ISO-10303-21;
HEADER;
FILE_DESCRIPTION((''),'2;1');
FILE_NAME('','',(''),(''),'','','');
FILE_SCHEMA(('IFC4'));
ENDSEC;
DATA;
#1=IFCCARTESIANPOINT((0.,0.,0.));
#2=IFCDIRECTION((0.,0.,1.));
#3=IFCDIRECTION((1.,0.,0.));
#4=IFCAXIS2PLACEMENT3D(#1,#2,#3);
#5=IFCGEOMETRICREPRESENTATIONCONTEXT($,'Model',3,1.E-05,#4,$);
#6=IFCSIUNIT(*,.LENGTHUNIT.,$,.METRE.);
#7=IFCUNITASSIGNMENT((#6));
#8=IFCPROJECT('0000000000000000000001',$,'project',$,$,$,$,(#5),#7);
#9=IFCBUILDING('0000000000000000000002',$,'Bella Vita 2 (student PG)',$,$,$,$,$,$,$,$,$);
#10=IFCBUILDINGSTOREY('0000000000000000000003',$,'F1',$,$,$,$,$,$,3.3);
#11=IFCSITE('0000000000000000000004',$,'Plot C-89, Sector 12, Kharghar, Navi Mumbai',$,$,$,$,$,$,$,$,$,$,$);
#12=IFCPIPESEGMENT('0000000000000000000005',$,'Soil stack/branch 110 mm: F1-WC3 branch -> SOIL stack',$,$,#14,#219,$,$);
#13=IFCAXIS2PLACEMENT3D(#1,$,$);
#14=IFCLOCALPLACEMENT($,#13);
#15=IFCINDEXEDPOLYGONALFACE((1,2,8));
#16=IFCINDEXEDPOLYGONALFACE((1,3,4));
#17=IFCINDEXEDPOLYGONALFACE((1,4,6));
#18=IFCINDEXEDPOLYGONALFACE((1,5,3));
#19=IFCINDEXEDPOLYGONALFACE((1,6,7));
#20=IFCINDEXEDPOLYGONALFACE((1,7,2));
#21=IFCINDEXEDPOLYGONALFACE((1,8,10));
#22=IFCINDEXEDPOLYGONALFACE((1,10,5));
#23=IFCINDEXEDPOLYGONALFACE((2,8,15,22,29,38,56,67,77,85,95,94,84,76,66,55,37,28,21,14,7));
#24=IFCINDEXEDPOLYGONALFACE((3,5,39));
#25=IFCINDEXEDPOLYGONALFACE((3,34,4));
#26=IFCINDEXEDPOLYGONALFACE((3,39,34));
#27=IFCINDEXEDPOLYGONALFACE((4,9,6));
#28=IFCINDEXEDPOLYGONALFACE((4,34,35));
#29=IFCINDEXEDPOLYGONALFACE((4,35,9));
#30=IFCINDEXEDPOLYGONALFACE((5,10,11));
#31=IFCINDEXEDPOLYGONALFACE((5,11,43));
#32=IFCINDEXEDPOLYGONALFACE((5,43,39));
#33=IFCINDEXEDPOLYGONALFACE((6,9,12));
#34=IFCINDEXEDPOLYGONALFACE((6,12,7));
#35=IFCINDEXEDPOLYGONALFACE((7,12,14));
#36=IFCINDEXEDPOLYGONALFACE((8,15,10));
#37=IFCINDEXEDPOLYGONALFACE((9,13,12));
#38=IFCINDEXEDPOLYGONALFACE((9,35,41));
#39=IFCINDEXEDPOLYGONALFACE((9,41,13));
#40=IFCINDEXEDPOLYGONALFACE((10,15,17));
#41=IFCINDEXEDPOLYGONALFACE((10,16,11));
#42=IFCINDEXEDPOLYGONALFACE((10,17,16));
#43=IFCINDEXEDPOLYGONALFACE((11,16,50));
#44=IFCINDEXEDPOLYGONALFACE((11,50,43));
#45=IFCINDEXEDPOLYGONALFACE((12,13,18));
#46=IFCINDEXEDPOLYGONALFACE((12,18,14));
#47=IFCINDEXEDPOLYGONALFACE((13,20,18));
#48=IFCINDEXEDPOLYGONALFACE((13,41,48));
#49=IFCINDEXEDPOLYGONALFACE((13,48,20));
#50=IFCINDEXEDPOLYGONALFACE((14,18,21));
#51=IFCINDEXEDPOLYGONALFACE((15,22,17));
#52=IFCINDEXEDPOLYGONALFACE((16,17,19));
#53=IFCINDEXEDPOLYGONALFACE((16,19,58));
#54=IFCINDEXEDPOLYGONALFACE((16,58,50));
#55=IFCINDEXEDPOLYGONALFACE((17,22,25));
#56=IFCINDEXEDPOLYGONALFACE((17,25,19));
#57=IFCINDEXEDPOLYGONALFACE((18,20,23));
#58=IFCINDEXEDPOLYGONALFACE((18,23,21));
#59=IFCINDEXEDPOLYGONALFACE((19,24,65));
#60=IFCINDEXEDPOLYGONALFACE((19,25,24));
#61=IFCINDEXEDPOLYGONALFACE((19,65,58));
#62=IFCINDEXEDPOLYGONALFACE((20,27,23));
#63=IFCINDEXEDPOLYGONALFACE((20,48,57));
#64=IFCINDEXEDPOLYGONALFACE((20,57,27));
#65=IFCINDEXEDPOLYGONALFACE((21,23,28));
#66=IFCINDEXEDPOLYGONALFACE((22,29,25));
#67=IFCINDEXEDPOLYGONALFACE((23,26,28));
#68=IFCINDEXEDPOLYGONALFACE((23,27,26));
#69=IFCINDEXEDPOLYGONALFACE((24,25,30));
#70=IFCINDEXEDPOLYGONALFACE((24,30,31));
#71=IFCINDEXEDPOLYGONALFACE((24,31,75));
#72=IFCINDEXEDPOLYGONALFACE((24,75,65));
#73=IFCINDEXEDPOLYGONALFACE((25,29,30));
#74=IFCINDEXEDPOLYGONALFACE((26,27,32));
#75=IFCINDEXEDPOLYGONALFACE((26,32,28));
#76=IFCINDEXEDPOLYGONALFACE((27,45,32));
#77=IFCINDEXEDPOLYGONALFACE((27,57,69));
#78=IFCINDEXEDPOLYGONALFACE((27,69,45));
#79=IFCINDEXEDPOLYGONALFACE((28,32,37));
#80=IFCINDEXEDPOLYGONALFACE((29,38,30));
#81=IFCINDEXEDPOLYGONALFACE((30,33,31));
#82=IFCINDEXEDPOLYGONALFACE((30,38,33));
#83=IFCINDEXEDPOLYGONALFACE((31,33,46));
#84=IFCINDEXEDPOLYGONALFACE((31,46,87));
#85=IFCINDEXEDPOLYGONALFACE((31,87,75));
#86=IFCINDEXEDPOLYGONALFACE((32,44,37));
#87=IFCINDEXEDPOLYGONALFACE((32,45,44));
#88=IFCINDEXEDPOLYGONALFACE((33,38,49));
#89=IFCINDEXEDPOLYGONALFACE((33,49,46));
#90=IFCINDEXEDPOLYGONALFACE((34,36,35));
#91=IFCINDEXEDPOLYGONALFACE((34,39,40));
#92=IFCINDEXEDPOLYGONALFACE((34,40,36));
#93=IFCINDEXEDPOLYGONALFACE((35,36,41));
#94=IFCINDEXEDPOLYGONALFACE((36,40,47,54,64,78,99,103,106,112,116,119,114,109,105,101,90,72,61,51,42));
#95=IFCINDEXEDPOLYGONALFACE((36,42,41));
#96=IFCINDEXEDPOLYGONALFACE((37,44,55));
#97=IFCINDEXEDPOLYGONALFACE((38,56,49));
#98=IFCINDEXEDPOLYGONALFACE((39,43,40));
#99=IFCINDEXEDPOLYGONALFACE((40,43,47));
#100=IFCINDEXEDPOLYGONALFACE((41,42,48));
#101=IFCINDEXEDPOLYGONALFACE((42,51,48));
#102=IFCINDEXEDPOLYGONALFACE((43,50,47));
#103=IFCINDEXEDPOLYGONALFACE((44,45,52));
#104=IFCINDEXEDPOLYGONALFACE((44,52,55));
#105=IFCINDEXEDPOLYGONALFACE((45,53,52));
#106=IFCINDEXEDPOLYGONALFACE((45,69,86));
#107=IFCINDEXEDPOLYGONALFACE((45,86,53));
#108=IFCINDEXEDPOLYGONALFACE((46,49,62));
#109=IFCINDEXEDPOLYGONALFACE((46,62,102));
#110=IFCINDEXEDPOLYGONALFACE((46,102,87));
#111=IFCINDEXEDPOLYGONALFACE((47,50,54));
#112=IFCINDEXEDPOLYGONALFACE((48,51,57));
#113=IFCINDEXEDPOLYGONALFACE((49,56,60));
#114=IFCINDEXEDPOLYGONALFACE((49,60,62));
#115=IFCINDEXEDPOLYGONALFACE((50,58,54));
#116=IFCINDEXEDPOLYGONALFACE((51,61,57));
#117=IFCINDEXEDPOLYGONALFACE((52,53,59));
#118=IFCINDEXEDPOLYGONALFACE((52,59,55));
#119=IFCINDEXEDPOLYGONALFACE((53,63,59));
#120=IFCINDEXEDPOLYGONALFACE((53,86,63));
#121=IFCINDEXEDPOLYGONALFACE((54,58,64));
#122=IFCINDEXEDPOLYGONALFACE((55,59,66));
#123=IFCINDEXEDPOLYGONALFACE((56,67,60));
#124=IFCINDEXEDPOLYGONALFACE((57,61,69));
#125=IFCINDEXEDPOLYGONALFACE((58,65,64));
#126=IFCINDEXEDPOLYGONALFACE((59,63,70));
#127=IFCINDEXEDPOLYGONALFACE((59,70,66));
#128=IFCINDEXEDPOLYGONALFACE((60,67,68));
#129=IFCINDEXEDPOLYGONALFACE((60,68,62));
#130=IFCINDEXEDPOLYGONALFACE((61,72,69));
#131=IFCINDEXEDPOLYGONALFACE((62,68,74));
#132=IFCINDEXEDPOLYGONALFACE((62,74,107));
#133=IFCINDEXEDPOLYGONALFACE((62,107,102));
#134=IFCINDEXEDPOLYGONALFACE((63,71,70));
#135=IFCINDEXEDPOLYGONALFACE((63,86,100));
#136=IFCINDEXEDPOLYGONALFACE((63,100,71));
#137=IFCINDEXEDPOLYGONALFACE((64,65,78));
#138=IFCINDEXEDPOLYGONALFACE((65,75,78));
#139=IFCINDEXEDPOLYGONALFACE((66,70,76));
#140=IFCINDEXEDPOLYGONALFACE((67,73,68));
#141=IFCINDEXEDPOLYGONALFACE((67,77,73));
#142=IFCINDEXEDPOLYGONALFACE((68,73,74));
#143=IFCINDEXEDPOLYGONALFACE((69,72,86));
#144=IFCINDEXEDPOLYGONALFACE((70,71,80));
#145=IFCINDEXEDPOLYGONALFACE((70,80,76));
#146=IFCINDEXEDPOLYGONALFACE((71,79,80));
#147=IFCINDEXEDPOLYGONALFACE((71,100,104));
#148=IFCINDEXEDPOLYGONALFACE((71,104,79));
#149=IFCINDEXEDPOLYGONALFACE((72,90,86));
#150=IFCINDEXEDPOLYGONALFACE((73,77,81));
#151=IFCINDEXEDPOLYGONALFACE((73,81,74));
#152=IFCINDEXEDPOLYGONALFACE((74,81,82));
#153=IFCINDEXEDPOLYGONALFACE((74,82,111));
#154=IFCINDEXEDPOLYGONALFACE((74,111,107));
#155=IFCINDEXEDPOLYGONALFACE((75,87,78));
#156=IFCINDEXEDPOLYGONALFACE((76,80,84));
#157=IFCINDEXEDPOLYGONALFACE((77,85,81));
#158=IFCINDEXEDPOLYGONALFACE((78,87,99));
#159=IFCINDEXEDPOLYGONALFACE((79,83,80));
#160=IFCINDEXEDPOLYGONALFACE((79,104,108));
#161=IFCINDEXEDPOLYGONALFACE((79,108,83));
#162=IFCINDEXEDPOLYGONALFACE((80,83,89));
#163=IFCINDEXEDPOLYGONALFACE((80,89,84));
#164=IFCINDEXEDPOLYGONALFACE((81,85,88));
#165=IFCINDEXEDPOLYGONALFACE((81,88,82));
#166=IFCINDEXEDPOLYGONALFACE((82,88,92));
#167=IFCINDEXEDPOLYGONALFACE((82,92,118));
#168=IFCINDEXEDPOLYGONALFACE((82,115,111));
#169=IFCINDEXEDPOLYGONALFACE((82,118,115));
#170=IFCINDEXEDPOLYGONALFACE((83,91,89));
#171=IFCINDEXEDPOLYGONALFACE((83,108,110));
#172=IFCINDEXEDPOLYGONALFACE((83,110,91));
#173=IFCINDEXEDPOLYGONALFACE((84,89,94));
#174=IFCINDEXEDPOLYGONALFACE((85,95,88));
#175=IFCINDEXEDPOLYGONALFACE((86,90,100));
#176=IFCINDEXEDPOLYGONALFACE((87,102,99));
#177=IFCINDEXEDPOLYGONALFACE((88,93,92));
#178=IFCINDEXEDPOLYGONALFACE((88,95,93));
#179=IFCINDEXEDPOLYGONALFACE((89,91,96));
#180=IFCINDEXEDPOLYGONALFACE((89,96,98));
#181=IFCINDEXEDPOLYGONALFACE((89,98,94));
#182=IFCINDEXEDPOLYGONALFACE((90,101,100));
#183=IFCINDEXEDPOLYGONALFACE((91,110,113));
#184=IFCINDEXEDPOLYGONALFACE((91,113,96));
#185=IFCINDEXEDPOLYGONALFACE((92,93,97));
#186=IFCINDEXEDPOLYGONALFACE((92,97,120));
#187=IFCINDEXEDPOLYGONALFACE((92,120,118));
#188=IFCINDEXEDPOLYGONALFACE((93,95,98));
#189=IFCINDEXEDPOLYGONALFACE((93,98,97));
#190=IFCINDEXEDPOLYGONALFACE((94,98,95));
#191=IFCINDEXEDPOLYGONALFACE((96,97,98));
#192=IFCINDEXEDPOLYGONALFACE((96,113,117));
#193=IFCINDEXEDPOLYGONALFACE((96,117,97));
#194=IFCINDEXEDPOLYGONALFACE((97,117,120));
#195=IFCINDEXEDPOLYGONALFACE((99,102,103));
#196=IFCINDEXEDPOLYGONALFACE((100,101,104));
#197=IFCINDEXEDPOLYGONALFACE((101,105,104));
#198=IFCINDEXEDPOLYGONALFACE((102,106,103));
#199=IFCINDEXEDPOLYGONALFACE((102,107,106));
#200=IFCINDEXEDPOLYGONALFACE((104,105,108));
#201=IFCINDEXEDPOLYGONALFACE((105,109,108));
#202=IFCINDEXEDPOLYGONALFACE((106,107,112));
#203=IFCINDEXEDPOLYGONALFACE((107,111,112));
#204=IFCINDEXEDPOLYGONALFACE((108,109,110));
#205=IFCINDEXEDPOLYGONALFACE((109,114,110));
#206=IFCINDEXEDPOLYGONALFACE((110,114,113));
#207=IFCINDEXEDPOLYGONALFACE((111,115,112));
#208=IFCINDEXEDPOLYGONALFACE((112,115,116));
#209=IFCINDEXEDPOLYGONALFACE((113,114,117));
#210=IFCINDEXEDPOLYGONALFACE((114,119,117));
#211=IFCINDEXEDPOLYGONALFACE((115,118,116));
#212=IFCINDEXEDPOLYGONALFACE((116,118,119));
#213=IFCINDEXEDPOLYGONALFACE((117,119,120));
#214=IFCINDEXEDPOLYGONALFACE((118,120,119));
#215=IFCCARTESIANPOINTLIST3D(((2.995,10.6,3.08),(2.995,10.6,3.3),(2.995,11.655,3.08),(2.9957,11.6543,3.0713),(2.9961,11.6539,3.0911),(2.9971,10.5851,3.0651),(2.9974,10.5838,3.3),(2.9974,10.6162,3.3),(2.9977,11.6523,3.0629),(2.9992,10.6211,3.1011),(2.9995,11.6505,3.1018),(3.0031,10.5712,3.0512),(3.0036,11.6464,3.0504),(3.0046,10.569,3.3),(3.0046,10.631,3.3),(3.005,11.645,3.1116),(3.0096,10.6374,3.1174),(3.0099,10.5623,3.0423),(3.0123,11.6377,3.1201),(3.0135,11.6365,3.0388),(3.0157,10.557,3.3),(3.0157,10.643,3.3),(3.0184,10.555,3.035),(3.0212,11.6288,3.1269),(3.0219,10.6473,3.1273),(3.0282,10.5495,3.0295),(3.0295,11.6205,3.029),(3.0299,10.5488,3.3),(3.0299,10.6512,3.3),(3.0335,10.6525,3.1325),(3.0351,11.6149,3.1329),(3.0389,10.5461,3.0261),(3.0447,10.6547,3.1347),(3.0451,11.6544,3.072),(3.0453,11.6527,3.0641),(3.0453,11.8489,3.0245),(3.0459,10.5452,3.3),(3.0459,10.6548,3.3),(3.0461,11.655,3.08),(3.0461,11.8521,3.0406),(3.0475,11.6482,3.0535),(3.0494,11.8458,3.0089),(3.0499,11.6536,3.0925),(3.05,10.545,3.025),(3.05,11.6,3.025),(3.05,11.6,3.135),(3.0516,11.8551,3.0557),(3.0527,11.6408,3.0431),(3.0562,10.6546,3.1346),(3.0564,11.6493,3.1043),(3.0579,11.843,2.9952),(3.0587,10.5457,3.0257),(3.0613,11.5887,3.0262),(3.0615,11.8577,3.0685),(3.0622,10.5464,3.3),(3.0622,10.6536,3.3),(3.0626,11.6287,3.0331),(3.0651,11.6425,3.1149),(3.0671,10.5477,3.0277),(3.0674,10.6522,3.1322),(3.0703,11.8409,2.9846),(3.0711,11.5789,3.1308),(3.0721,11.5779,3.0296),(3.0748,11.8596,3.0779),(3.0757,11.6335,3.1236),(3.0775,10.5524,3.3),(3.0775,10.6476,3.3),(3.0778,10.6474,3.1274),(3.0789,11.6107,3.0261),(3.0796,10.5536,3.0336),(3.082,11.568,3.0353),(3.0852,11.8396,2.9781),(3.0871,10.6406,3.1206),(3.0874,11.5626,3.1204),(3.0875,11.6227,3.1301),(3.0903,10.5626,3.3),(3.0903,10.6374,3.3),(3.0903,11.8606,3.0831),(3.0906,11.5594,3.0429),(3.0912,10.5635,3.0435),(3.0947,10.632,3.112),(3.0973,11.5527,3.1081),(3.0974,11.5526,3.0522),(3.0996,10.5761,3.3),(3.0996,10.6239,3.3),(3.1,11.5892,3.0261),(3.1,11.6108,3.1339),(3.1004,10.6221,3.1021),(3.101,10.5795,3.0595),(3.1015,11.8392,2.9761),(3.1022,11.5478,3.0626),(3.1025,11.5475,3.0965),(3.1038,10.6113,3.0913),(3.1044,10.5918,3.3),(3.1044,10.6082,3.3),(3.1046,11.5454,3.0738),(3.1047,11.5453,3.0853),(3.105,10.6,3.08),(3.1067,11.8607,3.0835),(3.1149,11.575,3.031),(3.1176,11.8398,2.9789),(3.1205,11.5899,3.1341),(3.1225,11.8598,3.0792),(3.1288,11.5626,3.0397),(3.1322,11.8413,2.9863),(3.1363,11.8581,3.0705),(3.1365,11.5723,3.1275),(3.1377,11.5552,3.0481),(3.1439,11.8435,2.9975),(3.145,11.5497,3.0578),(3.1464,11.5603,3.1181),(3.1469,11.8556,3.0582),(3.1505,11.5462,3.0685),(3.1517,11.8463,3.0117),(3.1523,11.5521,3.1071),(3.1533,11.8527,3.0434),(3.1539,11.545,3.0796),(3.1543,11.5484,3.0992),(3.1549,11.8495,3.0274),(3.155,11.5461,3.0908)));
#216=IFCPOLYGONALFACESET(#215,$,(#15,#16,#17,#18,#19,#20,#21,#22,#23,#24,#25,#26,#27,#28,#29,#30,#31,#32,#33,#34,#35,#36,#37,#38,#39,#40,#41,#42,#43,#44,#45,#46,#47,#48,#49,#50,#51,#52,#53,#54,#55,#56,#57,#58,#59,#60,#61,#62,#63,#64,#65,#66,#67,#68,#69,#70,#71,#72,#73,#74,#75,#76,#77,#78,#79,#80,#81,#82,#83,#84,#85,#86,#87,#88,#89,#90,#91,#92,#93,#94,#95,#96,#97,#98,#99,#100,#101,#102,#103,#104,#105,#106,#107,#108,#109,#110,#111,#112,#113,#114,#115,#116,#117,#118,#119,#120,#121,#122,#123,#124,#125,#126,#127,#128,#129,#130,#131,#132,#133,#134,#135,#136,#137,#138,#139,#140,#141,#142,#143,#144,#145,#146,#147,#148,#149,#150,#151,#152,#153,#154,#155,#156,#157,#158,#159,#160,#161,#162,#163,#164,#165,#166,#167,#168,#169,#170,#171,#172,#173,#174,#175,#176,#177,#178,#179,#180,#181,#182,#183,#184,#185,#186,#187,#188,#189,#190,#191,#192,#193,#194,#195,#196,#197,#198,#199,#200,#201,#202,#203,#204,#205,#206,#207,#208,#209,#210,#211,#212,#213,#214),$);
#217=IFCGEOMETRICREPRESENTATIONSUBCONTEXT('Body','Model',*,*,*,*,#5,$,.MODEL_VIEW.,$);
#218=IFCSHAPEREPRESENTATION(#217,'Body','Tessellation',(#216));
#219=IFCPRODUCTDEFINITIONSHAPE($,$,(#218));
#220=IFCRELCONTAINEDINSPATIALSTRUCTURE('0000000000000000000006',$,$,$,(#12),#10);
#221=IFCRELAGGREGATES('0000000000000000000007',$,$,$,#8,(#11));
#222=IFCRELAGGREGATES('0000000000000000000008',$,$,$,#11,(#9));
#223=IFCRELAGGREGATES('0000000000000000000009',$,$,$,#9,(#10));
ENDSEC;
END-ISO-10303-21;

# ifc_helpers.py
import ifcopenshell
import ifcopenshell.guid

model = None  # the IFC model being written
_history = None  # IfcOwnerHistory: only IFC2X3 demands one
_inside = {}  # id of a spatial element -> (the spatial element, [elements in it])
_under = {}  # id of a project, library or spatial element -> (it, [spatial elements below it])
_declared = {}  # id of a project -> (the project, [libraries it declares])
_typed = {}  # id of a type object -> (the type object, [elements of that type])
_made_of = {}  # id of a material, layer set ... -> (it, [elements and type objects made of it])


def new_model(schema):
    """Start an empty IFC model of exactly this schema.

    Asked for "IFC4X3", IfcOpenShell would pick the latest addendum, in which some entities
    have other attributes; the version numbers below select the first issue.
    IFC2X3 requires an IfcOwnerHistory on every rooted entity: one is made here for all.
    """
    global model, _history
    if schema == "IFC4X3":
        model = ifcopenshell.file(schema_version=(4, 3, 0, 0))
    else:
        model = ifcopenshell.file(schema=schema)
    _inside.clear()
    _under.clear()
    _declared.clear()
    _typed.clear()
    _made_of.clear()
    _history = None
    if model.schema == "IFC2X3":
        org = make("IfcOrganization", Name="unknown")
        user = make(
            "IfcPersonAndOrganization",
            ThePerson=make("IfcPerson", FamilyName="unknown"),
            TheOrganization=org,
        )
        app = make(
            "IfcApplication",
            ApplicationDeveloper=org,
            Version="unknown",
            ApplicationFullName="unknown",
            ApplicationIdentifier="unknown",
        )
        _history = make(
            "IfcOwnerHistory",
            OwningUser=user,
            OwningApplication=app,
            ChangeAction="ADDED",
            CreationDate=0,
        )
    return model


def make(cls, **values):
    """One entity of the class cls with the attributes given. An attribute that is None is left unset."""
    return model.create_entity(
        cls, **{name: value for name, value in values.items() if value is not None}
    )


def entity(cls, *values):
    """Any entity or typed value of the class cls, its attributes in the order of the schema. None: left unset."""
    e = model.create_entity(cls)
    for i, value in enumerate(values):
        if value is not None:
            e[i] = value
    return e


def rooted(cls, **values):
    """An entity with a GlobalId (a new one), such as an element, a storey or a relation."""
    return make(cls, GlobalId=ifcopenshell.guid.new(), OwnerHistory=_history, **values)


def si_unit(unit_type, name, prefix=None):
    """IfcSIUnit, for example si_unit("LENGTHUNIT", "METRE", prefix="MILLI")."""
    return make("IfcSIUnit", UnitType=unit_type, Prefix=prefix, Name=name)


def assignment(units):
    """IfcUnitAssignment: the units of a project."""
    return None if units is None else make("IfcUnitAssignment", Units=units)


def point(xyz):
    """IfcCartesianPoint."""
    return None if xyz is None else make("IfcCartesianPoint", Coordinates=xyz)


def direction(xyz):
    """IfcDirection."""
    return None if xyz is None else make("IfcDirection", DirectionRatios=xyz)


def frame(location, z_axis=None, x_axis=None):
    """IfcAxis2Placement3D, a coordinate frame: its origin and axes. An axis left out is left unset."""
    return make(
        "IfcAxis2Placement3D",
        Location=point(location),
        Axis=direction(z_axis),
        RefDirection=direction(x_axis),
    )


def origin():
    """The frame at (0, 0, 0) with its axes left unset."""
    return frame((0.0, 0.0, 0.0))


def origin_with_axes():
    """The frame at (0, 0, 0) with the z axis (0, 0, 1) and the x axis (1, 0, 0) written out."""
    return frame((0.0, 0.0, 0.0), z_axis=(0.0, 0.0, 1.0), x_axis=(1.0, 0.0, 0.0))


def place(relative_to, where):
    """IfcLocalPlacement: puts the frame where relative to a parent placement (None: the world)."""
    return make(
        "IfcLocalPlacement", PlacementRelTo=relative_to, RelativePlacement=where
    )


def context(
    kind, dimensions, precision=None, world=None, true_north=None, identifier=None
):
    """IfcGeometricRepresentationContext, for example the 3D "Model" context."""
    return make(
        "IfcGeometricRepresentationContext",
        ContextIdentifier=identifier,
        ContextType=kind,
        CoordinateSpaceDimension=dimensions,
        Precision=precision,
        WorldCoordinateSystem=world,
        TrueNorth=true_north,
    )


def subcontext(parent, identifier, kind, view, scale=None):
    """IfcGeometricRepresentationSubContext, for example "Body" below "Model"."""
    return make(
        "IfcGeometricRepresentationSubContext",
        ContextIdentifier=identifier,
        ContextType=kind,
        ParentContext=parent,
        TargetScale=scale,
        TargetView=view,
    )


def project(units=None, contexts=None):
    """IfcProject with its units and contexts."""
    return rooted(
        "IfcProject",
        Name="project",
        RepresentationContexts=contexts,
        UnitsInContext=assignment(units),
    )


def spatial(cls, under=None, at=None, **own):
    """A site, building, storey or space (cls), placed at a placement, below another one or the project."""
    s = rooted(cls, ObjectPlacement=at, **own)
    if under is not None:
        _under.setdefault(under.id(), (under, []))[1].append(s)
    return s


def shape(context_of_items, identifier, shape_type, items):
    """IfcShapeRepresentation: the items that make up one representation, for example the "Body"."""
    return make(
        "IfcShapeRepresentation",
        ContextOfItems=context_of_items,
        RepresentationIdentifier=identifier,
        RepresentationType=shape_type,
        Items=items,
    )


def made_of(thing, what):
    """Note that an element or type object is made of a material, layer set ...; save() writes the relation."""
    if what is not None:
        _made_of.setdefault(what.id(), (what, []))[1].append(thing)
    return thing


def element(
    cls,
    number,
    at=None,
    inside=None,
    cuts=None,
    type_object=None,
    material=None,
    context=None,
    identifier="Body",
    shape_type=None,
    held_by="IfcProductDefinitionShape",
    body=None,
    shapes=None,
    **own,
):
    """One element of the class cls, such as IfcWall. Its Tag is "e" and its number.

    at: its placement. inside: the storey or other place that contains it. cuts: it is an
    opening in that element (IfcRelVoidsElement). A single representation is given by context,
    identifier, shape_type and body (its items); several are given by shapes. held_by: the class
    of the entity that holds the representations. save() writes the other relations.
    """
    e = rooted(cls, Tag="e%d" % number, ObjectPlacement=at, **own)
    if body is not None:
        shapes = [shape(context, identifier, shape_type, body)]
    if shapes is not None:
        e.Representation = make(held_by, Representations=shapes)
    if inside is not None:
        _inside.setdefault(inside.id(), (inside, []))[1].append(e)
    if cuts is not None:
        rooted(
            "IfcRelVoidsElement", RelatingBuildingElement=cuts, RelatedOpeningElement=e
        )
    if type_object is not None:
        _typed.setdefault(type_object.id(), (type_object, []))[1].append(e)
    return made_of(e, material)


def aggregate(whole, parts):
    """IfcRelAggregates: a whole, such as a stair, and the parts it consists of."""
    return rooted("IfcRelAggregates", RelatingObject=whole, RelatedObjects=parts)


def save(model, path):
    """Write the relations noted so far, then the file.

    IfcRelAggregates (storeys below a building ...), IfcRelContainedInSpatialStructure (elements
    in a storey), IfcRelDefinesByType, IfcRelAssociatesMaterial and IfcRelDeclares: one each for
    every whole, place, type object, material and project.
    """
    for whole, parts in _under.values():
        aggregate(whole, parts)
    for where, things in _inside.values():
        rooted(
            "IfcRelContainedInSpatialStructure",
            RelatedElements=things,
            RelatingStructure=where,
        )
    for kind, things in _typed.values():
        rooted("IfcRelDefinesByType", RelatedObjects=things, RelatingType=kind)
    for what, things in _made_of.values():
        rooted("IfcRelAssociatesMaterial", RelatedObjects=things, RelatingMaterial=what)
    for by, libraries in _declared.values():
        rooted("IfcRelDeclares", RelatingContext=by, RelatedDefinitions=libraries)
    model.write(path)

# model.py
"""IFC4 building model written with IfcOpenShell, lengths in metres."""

from ifc_helpers import new_model, entity, si_unit, origin, origin_with_axes, place, context, subcontext, project, spatial, element, save


model = new_model("IFC4")

# Units and contexts
model_context = context("Model", 3, precision=1e-05, world=origin_with_axes())
body_context = subcontext(model_context, "Body", "Model", "MODEL_VIEW")
ifc_project = project(units=[si_unit("LENGTHUNIT", "METRE")], contexts=[model_context])

# Site, building, storey
site = spatial("IfcSite", under=ifc_project, Name="Plot C-89, Sector 12, Kharghar, Navi Mumbai")
building = spatial("IfcBuilding", under=site, Name="Bella Vita 2 (student PG)")
storey = spatial("IfcBuildingStorey", under=building, Name="F1", Elevation=3.3)

# Pipe segment
pipe_segment_1_placement = place(None, origin())
element("IfcPipeSegment", 1, at=pipe_segment_1_placement, inside=storey, Name="Soil stack/branch 110 mm: F1-WC3 branch -> SOIL stack", context=body_context, shape_type="AdvancedSweptSolid", body=[
    entity("IfcSweptDiskSolid", entity("IfcPolyline", [entity("IfcCartesianPoint", [3.05, 10.6, 3.3]), entity("IfcCartesianPoint", [3.05, 10.6, 3.08]), entity("IfcCartesianPoint", [3.05, 11.6, 3.08]), entity("IfcCartesianPoint", [3.1, 11.6, 3.08]), entity("IfcCartesianPoint", [3.1, 11.85, 3.03])]), 0.055),
])

save(model, "model.ifc")
